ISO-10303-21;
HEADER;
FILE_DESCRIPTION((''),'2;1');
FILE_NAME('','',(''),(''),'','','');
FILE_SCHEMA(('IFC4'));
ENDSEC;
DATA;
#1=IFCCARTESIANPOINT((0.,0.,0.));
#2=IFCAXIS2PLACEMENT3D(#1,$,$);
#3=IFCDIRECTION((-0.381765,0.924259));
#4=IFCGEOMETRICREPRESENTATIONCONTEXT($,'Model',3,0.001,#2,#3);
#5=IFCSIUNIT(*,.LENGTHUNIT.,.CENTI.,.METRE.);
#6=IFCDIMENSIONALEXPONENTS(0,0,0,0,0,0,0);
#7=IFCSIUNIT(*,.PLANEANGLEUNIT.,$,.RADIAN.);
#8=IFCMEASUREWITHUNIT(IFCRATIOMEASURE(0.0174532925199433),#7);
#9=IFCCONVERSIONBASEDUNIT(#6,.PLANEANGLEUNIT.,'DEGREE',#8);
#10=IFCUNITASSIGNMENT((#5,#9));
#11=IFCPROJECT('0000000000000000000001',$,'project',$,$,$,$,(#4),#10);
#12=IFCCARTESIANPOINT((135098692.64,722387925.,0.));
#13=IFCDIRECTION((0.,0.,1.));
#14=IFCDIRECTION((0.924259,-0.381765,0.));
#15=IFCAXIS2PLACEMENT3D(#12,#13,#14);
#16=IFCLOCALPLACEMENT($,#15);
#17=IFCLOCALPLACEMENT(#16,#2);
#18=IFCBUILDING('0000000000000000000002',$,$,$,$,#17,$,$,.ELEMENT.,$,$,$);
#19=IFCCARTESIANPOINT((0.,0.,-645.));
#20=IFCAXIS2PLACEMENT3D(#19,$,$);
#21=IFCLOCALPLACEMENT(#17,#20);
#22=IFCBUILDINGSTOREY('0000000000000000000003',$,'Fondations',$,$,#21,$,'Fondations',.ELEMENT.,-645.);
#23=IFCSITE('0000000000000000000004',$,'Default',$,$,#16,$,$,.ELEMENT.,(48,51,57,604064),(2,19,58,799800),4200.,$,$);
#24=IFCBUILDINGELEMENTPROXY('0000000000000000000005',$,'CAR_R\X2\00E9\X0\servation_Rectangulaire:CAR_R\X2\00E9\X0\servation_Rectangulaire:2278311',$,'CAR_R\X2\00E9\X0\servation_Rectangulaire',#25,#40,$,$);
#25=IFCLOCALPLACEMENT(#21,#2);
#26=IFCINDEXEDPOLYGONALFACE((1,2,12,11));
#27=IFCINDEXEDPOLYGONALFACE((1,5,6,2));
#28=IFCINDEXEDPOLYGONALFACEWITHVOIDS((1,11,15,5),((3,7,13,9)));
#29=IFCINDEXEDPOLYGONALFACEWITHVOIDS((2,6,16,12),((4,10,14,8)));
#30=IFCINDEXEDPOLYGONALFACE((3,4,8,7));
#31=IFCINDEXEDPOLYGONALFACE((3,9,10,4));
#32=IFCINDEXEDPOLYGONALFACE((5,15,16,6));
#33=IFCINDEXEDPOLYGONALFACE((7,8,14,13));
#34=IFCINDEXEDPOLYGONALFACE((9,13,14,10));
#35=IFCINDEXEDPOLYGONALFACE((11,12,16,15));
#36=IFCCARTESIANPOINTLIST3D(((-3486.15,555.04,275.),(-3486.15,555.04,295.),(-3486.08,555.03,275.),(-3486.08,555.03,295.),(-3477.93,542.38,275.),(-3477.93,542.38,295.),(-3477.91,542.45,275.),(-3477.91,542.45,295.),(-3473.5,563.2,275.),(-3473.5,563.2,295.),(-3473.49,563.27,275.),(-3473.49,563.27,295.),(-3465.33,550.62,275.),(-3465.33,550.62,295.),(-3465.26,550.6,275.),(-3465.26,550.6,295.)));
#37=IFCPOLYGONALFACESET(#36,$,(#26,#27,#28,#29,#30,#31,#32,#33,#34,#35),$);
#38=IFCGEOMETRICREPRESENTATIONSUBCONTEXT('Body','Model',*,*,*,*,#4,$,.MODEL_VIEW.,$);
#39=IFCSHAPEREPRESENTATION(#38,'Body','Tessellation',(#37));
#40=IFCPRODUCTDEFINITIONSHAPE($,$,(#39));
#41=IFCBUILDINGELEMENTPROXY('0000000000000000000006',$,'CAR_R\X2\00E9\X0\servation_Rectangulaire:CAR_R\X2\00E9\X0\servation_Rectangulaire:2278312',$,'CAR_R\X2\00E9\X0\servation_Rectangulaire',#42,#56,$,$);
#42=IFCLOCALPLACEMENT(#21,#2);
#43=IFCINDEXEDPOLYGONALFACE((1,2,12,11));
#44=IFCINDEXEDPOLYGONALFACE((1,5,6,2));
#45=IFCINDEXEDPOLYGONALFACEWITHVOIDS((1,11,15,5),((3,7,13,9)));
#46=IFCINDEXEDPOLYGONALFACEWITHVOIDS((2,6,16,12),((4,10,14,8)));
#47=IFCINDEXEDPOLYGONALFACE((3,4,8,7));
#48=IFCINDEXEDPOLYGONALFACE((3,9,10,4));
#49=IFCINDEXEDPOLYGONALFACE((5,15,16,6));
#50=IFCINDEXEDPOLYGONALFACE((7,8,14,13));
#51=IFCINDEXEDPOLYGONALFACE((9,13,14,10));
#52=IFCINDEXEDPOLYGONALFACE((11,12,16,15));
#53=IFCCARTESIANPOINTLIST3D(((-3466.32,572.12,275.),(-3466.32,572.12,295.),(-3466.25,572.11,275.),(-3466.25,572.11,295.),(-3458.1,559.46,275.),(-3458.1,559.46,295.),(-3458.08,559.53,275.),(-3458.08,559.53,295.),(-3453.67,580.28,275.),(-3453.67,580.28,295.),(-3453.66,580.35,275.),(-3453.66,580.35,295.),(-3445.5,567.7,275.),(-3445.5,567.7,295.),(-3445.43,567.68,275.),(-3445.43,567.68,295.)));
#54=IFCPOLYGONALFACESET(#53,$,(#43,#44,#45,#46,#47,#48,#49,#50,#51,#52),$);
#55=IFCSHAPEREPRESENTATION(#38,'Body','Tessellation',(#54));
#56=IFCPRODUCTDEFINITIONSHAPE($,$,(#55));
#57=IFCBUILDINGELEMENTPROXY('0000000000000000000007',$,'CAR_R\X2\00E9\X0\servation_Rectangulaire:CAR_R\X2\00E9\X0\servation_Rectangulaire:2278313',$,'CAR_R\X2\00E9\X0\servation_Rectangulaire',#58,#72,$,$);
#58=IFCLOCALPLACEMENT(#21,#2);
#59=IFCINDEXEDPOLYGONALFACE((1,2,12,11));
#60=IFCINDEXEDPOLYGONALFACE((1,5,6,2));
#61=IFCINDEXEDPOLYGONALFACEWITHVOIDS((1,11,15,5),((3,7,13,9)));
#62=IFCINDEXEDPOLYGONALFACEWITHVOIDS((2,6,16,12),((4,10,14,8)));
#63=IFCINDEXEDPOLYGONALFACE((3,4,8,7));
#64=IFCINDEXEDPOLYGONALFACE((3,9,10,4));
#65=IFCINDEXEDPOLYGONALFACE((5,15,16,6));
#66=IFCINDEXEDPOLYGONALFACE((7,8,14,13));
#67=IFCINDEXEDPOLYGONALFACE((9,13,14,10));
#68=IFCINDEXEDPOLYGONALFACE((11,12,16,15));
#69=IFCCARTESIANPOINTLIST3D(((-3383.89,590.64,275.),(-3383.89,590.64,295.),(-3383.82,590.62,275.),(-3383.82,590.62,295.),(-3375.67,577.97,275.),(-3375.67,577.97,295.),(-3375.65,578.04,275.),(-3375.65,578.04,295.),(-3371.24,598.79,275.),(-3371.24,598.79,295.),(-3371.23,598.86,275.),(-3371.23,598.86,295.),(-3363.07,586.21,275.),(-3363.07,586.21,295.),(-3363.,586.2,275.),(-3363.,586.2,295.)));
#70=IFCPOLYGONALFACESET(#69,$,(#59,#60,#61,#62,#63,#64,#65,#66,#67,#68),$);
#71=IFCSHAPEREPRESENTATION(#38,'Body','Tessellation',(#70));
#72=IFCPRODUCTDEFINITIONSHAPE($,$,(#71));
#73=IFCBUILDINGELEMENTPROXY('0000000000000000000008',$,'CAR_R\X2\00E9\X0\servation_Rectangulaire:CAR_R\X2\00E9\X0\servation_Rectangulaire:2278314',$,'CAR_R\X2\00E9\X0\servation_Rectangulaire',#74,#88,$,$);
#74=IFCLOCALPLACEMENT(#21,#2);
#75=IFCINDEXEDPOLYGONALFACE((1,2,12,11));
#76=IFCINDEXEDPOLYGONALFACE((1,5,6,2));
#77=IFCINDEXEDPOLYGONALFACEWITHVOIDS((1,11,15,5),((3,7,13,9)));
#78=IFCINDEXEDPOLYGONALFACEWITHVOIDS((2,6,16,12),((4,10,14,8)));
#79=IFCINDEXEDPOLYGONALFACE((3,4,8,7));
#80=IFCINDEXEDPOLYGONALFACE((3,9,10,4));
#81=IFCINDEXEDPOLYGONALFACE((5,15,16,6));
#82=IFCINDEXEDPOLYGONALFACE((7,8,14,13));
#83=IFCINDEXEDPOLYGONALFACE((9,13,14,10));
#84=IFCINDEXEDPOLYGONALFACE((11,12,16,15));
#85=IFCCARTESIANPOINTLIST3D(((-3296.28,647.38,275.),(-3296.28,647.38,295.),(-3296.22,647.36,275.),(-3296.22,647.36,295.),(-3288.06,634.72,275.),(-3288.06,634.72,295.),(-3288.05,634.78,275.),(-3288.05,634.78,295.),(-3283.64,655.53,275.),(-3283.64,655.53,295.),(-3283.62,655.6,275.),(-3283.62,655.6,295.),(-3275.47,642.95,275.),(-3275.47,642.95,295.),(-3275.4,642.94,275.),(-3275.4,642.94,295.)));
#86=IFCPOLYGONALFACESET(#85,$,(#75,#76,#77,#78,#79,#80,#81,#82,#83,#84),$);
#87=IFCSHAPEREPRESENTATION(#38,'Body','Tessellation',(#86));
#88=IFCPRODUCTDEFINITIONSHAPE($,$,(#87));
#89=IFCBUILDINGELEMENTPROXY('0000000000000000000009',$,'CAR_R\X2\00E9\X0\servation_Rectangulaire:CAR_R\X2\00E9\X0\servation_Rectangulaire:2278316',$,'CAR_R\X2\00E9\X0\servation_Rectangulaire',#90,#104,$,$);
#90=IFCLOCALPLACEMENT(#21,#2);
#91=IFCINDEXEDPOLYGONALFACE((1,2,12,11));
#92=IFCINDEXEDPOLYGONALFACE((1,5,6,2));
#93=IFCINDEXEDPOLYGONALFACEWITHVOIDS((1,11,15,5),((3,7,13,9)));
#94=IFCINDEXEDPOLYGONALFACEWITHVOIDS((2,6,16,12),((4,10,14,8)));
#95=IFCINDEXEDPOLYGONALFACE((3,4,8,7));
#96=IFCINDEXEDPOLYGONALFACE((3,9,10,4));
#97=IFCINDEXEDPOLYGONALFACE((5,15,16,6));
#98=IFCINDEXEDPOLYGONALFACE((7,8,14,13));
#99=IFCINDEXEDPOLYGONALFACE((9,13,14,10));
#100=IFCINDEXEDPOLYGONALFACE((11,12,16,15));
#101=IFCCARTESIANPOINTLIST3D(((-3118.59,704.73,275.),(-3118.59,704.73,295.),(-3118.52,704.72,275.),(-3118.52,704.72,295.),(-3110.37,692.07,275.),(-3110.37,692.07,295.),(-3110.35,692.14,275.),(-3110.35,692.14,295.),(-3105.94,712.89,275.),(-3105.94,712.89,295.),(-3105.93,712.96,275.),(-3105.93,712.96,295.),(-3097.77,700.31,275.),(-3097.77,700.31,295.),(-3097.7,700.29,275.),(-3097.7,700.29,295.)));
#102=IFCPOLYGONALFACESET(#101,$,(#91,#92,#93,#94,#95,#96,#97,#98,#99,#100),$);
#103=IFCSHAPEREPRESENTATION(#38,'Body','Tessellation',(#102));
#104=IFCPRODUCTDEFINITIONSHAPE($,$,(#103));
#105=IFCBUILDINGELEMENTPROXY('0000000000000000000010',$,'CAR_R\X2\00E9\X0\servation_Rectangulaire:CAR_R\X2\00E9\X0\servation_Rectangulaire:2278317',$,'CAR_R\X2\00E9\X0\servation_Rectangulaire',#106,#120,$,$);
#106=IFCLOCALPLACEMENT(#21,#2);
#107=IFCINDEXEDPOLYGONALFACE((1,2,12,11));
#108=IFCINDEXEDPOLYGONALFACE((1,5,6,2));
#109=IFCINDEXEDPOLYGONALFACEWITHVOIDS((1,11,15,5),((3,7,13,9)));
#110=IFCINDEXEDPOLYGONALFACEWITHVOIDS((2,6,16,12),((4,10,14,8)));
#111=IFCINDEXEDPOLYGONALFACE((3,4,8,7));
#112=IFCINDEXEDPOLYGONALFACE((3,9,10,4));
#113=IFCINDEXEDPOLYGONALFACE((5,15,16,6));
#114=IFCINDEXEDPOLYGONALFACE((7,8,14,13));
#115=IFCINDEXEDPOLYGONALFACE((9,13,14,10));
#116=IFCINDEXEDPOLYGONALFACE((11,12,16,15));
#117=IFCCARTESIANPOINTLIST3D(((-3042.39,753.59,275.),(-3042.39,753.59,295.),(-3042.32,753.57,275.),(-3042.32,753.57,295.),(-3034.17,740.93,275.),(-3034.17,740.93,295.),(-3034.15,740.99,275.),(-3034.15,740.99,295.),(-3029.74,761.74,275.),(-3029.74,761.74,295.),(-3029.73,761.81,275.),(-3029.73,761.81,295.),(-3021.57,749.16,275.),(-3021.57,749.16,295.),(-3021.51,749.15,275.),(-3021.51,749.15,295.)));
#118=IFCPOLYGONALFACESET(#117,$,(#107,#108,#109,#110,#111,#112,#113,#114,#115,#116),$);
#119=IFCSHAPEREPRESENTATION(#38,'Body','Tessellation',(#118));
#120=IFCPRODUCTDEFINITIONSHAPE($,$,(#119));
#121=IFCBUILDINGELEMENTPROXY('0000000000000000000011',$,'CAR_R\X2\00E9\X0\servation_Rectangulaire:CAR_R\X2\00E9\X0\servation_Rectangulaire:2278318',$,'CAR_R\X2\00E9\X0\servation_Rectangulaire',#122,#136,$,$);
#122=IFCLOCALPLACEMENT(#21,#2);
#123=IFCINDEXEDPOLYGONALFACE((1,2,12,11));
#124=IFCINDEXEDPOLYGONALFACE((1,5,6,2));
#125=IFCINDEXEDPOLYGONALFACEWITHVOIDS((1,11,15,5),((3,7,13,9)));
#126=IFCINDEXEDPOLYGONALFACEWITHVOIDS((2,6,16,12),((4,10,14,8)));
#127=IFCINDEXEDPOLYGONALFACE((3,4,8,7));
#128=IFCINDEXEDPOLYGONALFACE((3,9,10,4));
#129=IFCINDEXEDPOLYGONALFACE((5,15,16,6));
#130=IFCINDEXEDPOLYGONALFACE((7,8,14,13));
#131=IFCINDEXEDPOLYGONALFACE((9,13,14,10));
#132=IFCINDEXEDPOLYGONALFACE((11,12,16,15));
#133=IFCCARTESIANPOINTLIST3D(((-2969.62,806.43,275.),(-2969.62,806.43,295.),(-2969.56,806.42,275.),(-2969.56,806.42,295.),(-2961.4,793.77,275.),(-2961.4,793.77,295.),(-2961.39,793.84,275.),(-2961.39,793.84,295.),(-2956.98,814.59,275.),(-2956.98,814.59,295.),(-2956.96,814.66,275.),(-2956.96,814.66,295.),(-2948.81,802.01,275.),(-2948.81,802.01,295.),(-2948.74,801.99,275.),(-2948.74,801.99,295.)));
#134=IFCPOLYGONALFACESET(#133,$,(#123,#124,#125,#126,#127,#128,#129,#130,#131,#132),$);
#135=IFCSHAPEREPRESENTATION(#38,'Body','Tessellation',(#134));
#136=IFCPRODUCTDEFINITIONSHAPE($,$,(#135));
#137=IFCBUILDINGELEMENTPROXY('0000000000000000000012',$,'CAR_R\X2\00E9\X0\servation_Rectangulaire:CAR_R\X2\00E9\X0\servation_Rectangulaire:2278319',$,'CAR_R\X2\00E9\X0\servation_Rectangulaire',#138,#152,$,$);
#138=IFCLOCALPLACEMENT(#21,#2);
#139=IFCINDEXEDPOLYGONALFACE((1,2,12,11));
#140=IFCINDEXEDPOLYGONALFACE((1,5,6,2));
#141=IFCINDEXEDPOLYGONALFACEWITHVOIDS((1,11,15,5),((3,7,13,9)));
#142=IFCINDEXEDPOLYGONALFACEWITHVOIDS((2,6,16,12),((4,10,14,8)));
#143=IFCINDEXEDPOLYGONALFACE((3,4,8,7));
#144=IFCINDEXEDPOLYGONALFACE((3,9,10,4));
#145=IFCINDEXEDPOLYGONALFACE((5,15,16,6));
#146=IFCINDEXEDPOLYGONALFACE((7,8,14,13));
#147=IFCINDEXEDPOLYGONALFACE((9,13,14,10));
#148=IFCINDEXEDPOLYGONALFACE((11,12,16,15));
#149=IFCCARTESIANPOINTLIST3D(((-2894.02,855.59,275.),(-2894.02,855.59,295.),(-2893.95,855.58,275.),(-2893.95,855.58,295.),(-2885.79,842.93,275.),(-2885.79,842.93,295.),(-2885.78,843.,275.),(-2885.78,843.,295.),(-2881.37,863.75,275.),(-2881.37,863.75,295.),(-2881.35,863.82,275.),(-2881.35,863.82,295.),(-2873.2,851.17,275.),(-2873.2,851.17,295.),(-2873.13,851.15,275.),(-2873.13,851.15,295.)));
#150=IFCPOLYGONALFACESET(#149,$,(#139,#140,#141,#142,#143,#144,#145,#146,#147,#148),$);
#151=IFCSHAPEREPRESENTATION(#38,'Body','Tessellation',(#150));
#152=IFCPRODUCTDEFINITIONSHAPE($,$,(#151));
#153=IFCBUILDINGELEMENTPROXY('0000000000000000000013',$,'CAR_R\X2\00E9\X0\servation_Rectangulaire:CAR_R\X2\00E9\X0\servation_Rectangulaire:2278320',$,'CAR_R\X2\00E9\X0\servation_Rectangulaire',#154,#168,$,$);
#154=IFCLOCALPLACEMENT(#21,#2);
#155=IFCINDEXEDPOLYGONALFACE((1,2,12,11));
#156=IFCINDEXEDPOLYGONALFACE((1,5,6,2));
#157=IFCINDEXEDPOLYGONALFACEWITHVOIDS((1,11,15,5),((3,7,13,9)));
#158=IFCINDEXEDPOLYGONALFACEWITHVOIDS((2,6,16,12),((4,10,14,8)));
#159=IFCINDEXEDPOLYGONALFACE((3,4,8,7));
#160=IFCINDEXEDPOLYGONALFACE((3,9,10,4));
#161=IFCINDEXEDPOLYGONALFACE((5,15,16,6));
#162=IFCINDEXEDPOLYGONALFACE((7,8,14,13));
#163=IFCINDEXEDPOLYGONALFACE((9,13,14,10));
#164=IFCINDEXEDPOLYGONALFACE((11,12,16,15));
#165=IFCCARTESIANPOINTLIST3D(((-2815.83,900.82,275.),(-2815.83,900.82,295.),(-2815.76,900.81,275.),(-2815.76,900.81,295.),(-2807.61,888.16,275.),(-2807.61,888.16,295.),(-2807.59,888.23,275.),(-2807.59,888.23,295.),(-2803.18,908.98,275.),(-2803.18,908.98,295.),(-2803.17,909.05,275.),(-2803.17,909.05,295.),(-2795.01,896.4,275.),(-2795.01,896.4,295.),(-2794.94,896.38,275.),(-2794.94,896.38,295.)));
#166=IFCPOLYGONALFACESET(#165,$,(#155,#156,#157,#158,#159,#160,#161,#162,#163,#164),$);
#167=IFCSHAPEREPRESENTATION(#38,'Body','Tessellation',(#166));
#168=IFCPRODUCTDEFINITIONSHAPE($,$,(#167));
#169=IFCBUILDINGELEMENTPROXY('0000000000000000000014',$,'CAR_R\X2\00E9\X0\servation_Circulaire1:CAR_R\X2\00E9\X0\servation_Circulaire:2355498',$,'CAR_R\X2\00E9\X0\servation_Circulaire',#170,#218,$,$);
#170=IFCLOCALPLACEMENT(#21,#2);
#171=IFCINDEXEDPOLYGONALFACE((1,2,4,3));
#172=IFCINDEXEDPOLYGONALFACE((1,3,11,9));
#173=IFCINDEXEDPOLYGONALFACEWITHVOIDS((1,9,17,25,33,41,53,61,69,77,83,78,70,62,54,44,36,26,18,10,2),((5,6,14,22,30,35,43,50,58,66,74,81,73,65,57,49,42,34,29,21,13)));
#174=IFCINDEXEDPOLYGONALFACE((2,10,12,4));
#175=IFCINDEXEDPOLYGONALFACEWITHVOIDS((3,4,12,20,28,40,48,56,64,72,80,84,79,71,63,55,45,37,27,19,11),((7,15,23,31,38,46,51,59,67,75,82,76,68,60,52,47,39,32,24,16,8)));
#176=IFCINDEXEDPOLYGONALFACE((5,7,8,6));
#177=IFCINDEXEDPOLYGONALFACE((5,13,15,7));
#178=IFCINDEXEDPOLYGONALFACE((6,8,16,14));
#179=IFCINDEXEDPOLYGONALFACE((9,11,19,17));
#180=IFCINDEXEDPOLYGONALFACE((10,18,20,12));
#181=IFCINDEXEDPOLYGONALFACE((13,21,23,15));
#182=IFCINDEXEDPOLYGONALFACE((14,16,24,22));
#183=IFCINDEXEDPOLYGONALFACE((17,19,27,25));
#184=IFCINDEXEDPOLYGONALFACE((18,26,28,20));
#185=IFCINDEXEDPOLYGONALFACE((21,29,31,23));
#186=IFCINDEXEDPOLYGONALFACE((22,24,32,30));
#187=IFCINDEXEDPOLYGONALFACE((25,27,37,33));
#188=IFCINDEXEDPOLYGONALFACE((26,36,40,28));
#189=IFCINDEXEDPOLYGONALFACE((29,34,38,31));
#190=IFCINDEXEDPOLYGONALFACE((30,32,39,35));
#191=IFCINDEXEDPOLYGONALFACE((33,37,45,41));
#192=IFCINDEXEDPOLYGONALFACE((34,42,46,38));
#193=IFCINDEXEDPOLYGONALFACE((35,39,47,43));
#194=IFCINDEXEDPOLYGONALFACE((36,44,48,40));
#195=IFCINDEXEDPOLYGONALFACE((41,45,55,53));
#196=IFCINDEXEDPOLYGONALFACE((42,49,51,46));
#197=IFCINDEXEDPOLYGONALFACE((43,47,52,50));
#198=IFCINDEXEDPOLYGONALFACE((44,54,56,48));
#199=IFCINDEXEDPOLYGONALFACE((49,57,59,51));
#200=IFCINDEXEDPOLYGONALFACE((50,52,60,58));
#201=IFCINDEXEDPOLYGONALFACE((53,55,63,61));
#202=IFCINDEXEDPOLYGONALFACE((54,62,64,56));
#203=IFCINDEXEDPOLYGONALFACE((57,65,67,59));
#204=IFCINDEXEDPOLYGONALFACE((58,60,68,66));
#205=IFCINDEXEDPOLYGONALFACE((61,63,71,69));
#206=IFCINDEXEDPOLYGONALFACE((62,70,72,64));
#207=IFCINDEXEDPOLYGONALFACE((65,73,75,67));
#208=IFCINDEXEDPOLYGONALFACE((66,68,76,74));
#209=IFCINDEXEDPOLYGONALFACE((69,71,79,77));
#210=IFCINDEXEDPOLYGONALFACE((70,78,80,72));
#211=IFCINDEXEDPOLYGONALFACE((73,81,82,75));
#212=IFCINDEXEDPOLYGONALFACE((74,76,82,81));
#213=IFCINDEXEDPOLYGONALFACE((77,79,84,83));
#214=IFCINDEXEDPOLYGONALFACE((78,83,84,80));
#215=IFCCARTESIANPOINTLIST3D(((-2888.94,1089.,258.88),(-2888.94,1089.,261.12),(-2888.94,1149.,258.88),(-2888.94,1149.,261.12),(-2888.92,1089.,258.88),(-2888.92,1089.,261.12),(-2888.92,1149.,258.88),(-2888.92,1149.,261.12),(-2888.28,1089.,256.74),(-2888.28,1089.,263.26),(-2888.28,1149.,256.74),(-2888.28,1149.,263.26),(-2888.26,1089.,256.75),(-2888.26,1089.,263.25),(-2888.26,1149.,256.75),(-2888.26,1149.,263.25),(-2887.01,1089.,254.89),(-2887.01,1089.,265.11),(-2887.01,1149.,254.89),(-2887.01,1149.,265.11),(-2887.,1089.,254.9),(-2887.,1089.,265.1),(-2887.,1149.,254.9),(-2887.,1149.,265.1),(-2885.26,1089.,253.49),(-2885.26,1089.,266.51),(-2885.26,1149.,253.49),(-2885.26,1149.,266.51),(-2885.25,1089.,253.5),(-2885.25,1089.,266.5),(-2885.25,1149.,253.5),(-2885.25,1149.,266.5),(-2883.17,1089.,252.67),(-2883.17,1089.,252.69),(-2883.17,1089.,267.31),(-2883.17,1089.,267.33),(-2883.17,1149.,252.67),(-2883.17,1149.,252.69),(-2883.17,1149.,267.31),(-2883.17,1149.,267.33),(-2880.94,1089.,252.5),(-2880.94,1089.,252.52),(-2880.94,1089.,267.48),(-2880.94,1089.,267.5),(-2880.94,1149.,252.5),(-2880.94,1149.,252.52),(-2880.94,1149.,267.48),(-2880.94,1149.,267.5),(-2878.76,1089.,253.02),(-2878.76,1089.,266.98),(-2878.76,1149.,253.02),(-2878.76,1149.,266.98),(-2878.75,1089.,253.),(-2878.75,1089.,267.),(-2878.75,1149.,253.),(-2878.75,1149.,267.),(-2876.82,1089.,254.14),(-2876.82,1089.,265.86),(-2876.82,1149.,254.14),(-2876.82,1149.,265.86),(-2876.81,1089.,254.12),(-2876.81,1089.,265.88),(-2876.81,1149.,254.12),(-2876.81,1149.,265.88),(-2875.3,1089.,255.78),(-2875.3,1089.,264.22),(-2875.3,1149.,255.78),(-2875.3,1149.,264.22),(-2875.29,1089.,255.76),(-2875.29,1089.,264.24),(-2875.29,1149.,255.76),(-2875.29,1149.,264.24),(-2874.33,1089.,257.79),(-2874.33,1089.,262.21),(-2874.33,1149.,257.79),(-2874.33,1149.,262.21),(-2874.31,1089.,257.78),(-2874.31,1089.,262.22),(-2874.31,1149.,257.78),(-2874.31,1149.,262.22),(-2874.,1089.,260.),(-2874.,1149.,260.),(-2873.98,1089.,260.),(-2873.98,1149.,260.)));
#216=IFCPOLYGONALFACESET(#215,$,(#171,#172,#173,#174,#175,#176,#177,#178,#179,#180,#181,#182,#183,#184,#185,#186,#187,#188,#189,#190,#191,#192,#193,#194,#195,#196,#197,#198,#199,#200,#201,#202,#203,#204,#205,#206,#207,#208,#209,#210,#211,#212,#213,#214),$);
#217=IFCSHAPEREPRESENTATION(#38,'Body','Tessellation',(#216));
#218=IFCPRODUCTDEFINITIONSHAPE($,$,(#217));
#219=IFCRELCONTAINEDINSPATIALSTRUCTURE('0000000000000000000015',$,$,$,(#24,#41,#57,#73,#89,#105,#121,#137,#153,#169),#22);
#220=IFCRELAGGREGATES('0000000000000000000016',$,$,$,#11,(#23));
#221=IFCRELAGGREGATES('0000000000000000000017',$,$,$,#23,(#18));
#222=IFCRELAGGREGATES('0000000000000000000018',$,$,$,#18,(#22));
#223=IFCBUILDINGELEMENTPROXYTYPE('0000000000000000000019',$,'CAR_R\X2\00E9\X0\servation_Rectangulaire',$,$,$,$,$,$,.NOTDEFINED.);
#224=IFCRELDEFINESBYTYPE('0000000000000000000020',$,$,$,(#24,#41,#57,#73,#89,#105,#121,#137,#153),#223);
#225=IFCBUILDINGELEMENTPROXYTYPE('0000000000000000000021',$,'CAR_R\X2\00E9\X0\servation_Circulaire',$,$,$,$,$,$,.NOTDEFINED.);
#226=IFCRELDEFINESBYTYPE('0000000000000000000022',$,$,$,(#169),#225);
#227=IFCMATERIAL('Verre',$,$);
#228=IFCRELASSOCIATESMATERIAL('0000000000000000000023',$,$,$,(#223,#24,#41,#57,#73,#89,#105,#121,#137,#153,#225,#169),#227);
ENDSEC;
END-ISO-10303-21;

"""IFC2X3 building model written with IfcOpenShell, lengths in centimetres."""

from ifc_helpers import new_model, entity, si_unit, converted_unit, direction, frame, frame_2d, origin, place, context, subcontext, project, spatial, polyline, hollow_circle, outline, extrude, source, transform, mapped, material, type_object, type_shapes, element, save


model = new_model("IFC2X3")

# Units and contexts
model_context = context("Model", 3, precision=0.001, world=origin(), true_north=direction((-0.381765, 0.924259)))
body_context = subcontext(model_context, "Body", "Model", "MODEL_VIEW")
ifc_project = project(units=[si_unit("LENGTHUNIT", "METRE", prefix="CENTI"), converted_unit("PLANEANGLEUNIT", "DEGREE", entity("IfcRatioMeasure", 0.0174532925199433), si_unit("PLANEANGLEUNIT", "RADIAN"), dimensions=[0, 0, 0, 0, 0, 0, 0])], contexts=[model_context])

# Site, building, storey
site_placement = place(None, frame((135098692.64, 722387925.0, 0.0), z_axis=(0.0, 0.0, 1.0), x_axis=(0.924259, -0.381765, 0.0)))
site = spatial("IfcSite", under=ifc_project, at=site_placement, Name="Default", CompositionType="ELEMENT", RefLatitude=(48, 51, 57, 604064), RefLongitude=(2, 19, 58, 799800), RefElevation=4200.0)
building_placement = place(site_placement, origin())
building = spatial("IfcBuilding", under=site, at=building_placement, CompositionType="ELEMENT")
storey_placement = place(building_placement, frame((0.0, 0.0, -645.0)))
storey = spatial("IfcBuildingStorey", under=building, at=storey_placement, Name="Fondations", LongName="Fondations", CompositionType="ELEMENT", Elevation=-645.0)

# Building element proxies
ifc_material_1 = material(Name="Verre")
building_element_proxy_type_1 = type_object("IfcBuildingElementProxyType", Name="CAR_Réservation_Rectangulaire", PredefinedType="NOTDEFINED", material=ifc_material_1)
shared_shape_1 = source(origin(), body_context, "Body", "SweptSolid", [
    extrude(outline(polyline([(-7.55, -7.55), (7.55, -7.55), (7.55, 7.55), (-7.55, 7.55), (-7.55, -7.55)]), holes=[polyline([(7.5, -7.5), (-7.5, -7.5), (-7.5, 7.5), (7.5, 7.5), (7.5, -7.5)])]), frame((0.0, 0.0, -20.0), z_axis=(0.0, 0.0, 1.0), x_axis=(-1.0, 0.0, 0.0)), (0.0, 0.0, 1.0), 20.0),
])
type_shapes(building_element_proxy_type_1, [shared_shape_1])
for number, where, z_axis, x_axis, name in (
    (1, (-3475.71, 552.82, 295.0), (0.0, 0.0, 1.0), (-0.544639, 0.838671, 0.0), "CAR_Réservation_Rectangulaire:CAR_Réservation_Rectangulaire:2278311"),
    (2, (-3455.88, 569.9, 295.0), (0.0, 0.0, 1.0), (-0.544639, 0.838671, 0.0), "CAR_Réservation_Rectangulaire:CAR_Réservation_Rectangulaire:2278312"),
    (3, (-3373.45, 588.42, 295.0), (0.0, 0.0, 1.0), (-0.544639, 0.838671, 0.0), "CAR_Réservation_Rectangulaire:CAR_Réservation_Rectangulaire:2278313"),
    (4, (-3285.84, 645.16, 295.0), (0.0, 0.0, 1.0), (-0.544639, 0.838671, 0.0), "CAR_Réservation_Rectangulaire:CAR_Réservation_Rectangulaire:2278314"),
    (5, (-3108.15, 702.51, 295.0), (0.0, 0.0, 1.0), (-0.544639, 0.838671, 0.0), "CAR_Réservation_Rectangulaire:CAR_Réservation_Rectangulaire:2278316"),
    (6, (-3031.95, 751.37, 295.0), (0.0, 0.0, 1.0), (-0.544639, 0.838671, 0.0), "CAR_Réservation_Rectangulaire:CAR_Réservation_Rectangulaire:2278317"),
    (7, (-2959.18, 804.21, 295.0), (0.0, 0.0, 1.0), (-0.544639, 0.838671, 0.0), "CAR_Réservation_Rectangulaire:CAR_Réservation_Rectangulaire:2278318"),
    (8, (-2883.57, 853.37, 295.0), (0.0, 0.0, 1.0), (-0.544639, 0.838671, 0.0), "CAR_Réservation_Rectangulaire:CAR_Réservation_Rectangulaire:2278319"),
    (9, (-2805.39, 898.6, 295.0), (0.0, 0.0, 1.0), (-0.544639, 0.838671, 0.0), "CAR_Réservation_Rectangulaire:CAR_Réservation_Rectangulaire:2278320"),
):
    element("IfcBuildingElementProxy", number, at=place(storey_placement, frame(where, z_axis=z_axis, x_axis=x_axis)), inside=storey, type_object=building_element_proxy_type_1, material=ifc_material_1, Name=name, ObjectType="CAR_Réservation_Rectangulaire", context=body_context, shape_type="MappedRepresentation", body=[
        mapped(shared_shape_1, transform((0.0, 0.0, 0.0), scale=1.0)),
    ])
building_element_proxy_type_2 = type_object("IfcBuildingElementProxyType", Name="CAR_Réservation_Circulaire", PredefinedType="NOTDEFINED", material=ifc_material_1)
shared_shape_2 = source(origin(), body_context, "Body", "SweptSolid", [
    extrude(hollow_circle(Radius=7.52, WallThickness=0.02, at=frame_2d((0.0, 0.0), x_axis=(1.0, 0.0))), frame((0.0, 0.0, -60.0)), (0.0, 0.0, 1.0), 60.0),
])
type_shapes(building_element_proxy_type_2, [shared_shape_2])
proxy_1_placement = place(storey_placement, frame((-2881.5, 1089.0, 260.0), z_axis=(0.0, -1.0, 0.0), x_axis=(1.0, 0.0, 0.0)))
element("IfcBuildingElementProxy", 10, at=proxy_1_placement, inside=storey, type_object=building_element_proxy_type_2, material=ifc_material_1, Name="CAR_Réservation_Circulaire1:CAR_Réservation_Circulaire:2355498", ObjectType="CAR_Réservation_Circulaire", context=body_context, shape_type="MappedRepresentation", body=[
    mapped(shared_shape_2, transform((0.0, 0.0, 0.0), scale=1.0)),
])

save(model, "model.ifc")
